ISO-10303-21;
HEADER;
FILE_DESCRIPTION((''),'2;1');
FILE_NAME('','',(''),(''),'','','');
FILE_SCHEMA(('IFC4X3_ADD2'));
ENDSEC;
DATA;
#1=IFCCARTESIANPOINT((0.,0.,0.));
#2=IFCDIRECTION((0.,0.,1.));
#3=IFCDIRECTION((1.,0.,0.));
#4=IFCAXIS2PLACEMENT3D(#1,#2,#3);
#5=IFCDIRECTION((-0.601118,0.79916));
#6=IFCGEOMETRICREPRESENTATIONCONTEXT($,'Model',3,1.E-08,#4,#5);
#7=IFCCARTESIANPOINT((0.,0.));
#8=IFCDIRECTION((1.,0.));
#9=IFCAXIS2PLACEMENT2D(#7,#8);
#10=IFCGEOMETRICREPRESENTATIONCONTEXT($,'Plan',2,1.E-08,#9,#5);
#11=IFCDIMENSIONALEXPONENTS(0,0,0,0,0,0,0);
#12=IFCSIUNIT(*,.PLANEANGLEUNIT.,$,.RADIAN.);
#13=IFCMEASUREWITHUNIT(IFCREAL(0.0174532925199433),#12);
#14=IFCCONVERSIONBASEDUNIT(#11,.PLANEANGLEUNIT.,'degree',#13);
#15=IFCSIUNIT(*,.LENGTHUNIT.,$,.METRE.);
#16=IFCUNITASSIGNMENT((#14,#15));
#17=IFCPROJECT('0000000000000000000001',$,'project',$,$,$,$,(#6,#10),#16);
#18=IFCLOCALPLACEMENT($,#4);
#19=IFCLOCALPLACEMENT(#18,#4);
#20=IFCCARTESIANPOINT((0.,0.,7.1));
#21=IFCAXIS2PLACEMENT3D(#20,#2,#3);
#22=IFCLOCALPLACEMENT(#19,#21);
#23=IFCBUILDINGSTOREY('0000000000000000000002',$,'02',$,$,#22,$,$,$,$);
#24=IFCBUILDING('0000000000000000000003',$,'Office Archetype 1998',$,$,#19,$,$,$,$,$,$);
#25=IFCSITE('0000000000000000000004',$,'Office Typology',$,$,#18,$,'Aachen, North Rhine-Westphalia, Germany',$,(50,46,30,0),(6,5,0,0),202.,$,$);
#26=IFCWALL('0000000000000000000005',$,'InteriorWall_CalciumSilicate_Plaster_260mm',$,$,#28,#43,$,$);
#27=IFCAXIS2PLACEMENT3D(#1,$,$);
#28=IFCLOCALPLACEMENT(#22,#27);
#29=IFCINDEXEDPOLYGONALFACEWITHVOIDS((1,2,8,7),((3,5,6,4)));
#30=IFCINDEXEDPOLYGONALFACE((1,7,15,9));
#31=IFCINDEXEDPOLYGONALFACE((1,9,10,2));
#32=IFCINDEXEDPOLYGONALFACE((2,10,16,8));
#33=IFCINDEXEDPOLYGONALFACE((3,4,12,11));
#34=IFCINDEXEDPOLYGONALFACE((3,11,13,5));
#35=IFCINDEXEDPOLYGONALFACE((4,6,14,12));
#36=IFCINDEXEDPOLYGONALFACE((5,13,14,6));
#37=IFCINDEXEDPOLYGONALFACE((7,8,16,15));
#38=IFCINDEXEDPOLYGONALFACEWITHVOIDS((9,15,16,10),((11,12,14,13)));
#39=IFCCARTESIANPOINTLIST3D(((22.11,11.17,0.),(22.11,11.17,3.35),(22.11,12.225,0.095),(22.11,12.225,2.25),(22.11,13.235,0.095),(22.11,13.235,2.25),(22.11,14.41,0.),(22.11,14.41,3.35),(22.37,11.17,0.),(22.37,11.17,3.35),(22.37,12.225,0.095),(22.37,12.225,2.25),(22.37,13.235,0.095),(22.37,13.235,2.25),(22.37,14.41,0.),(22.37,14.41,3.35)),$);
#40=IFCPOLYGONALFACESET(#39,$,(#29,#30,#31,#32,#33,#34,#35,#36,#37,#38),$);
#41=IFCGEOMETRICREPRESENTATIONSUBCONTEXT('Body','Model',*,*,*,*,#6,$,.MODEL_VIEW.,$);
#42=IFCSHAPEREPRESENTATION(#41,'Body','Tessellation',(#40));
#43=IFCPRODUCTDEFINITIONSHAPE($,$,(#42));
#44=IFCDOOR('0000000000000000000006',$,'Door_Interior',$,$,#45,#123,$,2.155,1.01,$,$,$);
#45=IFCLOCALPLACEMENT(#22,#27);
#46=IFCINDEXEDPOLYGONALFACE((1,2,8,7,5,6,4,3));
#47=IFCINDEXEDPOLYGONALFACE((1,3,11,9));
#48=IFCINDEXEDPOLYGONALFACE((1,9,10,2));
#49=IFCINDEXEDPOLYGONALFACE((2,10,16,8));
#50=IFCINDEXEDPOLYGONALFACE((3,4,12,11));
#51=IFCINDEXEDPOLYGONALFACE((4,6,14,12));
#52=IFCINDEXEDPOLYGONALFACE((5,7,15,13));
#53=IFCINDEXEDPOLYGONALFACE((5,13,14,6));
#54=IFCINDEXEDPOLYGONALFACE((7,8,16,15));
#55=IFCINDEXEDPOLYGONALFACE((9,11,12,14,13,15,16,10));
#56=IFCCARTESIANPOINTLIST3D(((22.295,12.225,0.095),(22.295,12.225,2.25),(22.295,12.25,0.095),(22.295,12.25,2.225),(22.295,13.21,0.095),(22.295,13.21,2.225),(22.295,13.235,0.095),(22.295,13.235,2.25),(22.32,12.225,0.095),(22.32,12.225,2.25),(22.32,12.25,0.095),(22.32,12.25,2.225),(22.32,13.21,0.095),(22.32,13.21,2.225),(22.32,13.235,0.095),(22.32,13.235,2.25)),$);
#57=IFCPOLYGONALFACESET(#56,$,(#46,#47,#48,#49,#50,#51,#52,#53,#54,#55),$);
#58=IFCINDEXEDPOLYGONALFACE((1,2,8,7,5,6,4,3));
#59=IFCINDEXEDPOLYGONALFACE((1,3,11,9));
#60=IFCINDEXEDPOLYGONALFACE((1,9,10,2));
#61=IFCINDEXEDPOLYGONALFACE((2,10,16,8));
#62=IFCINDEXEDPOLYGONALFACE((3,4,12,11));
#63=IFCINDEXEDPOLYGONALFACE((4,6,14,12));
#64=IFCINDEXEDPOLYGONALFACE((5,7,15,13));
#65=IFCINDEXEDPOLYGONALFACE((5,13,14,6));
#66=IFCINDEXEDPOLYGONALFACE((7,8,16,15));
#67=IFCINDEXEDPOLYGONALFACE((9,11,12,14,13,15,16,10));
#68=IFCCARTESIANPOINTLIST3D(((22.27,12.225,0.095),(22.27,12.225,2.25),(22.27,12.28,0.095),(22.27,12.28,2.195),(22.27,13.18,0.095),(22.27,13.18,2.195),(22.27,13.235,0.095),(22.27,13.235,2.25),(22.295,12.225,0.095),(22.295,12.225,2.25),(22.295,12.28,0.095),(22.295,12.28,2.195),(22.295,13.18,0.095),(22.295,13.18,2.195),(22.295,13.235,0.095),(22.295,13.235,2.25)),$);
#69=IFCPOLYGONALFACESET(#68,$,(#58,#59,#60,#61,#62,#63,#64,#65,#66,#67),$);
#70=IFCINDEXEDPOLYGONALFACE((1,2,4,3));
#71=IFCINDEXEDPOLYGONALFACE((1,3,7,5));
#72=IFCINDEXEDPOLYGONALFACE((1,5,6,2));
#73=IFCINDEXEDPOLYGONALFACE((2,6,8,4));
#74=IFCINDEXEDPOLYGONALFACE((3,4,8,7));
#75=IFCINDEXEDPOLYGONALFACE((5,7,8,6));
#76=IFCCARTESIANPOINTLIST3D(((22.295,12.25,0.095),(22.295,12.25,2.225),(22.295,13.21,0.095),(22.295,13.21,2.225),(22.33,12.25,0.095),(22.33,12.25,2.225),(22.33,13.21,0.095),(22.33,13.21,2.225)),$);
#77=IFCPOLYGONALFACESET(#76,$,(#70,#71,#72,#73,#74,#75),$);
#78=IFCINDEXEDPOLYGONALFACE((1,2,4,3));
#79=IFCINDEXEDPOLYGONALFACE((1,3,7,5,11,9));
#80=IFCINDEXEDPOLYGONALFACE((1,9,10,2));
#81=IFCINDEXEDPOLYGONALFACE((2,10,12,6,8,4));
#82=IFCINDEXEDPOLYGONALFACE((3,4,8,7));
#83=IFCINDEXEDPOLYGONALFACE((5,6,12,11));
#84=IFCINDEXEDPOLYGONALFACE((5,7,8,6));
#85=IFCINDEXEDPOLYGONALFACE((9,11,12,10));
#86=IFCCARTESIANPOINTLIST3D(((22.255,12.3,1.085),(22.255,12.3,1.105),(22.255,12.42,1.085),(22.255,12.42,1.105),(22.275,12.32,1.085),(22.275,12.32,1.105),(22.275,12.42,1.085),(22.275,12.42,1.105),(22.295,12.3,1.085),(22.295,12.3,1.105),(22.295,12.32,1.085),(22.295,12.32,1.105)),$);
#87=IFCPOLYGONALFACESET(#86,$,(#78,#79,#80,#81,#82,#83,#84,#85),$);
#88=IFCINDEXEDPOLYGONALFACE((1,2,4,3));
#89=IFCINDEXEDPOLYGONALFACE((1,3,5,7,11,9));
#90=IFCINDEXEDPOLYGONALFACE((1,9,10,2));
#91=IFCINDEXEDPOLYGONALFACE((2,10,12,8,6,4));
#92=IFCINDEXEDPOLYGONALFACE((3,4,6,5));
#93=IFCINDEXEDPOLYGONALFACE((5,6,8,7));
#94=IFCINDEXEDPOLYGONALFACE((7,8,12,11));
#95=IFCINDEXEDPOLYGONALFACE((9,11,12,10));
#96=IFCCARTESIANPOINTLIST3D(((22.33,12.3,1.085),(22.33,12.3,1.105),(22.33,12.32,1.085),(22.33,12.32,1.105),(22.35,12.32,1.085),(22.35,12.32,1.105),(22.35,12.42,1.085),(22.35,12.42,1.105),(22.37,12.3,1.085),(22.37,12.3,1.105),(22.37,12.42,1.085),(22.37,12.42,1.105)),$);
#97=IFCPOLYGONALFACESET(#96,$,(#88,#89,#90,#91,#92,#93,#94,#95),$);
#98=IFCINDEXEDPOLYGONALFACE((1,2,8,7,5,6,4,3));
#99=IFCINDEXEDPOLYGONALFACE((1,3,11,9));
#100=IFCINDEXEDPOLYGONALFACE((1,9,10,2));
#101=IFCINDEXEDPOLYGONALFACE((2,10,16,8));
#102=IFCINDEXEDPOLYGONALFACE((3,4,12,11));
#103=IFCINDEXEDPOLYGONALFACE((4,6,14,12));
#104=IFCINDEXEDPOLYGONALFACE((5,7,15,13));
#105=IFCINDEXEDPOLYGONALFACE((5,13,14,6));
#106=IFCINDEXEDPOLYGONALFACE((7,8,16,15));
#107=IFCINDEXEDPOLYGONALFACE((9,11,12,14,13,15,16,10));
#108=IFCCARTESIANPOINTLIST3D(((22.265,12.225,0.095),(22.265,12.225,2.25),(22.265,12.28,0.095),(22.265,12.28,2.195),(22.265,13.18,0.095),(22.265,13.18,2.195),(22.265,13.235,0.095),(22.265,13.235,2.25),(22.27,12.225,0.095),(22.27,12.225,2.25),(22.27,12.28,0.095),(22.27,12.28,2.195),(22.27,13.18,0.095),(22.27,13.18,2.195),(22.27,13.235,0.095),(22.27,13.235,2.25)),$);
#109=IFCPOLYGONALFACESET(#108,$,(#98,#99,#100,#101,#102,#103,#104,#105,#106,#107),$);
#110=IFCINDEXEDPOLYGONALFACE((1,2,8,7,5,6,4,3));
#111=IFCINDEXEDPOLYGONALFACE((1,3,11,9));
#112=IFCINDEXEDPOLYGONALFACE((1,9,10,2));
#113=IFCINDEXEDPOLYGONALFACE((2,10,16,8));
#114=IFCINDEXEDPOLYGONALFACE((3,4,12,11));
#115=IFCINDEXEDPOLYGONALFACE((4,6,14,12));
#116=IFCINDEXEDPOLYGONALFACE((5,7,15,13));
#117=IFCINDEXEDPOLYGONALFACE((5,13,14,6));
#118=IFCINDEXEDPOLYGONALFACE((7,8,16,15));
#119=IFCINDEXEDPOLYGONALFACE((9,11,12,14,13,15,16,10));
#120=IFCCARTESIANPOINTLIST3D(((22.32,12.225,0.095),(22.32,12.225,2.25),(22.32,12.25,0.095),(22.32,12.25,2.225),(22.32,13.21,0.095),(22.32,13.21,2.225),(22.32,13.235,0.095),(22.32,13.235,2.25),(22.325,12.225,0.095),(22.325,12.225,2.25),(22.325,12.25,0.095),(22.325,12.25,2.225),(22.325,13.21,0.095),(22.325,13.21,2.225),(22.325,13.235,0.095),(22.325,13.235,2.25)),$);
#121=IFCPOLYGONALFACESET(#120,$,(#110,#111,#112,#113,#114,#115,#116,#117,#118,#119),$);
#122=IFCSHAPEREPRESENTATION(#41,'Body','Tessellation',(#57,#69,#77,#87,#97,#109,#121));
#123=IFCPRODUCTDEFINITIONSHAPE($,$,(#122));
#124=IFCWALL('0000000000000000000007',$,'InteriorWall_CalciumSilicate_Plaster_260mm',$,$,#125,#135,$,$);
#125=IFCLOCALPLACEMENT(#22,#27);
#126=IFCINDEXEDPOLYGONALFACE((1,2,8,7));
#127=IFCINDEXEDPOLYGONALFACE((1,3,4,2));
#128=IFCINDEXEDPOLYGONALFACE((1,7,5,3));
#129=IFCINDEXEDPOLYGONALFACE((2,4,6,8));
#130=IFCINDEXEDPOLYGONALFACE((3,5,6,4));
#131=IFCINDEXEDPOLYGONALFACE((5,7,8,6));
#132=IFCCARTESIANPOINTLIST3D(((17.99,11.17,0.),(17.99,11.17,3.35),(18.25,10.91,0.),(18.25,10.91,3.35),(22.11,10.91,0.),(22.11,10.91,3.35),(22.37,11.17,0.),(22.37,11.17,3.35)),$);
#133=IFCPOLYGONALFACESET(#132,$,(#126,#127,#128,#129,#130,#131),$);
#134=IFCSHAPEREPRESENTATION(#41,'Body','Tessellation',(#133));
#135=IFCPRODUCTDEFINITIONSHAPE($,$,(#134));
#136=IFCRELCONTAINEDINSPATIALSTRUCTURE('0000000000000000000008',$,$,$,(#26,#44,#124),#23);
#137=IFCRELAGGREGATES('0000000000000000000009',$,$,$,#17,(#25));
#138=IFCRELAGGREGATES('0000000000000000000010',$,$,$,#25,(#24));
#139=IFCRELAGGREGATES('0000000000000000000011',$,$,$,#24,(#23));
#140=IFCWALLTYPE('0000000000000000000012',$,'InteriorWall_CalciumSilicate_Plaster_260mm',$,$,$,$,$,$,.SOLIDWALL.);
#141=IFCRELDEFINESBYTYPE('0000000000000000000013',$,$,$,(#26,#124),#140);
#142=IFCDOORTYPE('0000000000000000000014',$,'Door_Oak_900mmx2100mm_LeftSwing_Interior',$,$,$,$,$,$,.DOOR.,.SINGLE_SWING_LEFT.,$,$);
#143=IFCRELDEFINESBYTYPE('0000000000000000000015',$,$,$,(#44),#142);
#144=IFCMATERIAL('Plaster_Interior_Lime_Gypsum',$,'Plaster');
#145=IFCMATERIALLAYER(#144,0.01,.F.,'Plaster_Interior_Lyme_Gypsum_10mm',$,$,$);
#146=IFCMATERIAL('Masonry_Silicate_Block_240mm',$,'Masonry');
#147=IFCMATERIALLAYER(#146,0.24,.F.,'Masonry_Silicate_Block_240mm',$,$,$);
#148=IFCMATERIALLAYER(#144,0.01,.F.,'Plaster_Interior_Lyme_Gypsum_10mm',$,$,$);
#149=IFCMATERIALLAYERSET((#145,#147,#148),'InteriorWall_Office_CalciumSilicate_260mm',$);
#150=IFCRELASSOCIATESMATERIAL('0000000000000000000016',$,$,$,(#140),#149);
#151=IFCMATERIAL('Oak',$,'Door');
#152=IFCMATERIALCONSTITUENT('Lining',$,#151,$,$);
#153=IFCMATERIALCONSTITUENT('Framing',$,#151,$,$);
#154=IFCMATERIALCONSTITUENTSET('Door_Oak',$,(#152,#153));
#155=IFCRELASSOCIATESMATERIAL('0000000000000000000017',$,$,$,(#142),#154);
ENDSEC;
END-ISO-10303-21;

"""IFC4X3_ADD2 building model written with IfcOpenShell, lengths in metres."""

from ifc_helpers import new_model, entity, si_unit, converted_unit, direction, frame, origin_with_axes, origin_2d_with_axis, place, context, subcontext, project, spatial, line, indexed_curve, outline, extrude, source, transform, mapped, material, layer, layer_set, constituent, constituent_set, type_object, type_shapes, element, fill, save


model = new_model("IFC4X3_ADD2")

# Units and contexts
model_context = context("Model", 3, precision=1e-08, world=origin_with_axes(), true_north=direction((-0.601118, 0.79916)))
plan_context = context("Plan", 2, precision=1e-08, world=origin_2d_with_axis(), true_north=direction((-0.601118, 0.79916)))
body_context = subcontext(model_context, "Body", "Model", "MODEL_VIEW")
ifc_project = project(units=[converted_unit("PLANEANGLEUNIT", "degree", entity("IfcReal", 0.0174532925199433), si_unit("PLANEANGLEUNIT", "RADIAN"), dimensions=[0, 0, 0, 0, 0, 0, 0]), si_unit("LENGTHUNIT", "METRE")], contexts=[model_context, plan_context])

# Site, building, storey
site_placement = place(None, origin_with_axes())
site = spatial("IfcSite", under=ifc_project, at=site_placement, Name="Office Typology", LongName="Aachen, North Rhine-Westphalia, Germany", RefLatitude=(50, 46, 30, 0), RefLongitude=(6, 5, 0, 0), RefElevation=202.0)
building_placement = place(site_placement, origin_with_axes())
building = spatial("IfcBuilding", under=site, at=building_placement, Name="Office Archetype 1998")
storey_placement = place(building_placement, frame((0.0, 0.0, 7.1), z_axis=(0.0, 0.0, 1.0), x_axis=(1.0, 0.0, 0.0)))
storey = spatial("IfcBuildingStorey", under=building, at=storey_placement, Name="02")

# Wall, opening, door
ifc_material_1 = material(Name="Plaster_Interior_Lime_Gypsum", Category="Plaster")
ifc_layer_1 = layer(ifc_material_1, 0.01, ventilated=False, Name="Plaster_Interior_Lyme_Gypsum_10mm")
ifc_material_2 = material(Name="Masonry_Silicate_Block_240mm", Category="Masonry")
ifc_layer_2 = layer(ifc_material_2, 0.24, ventilated=False, Name="Masonry_Silicate_Block_240mm")
ifc_layer_3 = layer(ifc_material_1, 0.01, ventilated=False, Name="Plaster_Interior_Lyme_Gypsum_10mm")
ifc_layer_set = layer_set([ifc_layer_1, ifc_layer_2, ifc_layer_3], Name="InteriorWall_Office_CalciumSilicate_260mm")
wall_type = type_object("IfcWallType", Name="InteriorWall_CalciumSilicate_Plaster_260mm", PredefinedType="SOLIDWALL", material=ifc_layer_set)
wall_1_placement = place(storey_placement, frame((22.37, 11.17, 0.0), z_axis=(0.0, 0.0, 1.0), x_axis=(0.0, 1.0, 0.0)))
wall_1 = element("IfcWall", 1, at=wall_1_placement, inside=storey, type_object=wall_type, Name="InteriorWall_CalciumSilicate_Plaster_260mm", context=body_context, shape_type="SweptSolid", body=[
    extrude(outline(indexed_curve([(0.0, 0.0), (0.0, 0.26), (3.24, 0.26), (3.24, 0.0)], segments=[line(1, 2, 3, 4, 1)])), origin_with_axes(), (0.0, 0.0, 1.0), 3.35),
])
shared_shape_1 = source(origin_with_axes(), body_context, "Body", "SweptSolid", [
    extrude(outline(indexed_curve([(0.0, 2.155), (1.01, 2.155), (1.01, 0.0), (0.0, 0.0), (0.0, 2.155)])), frame((0.0, -0.015, 0.0), z_axis=(0.0, -1.0, 0.0), x_axis=(1.0, 0.0, 0.0)), (0.0, 0.0, -1.0), 0.26),
])
opening_placement = place(wall_1_placement, frame((2.065, 0.245, 0.095), z_axis=(0.0, 0.0, 1.0), x_axis=(-1.0, 0.0, 0.0)))
opening = element("IfcOpeningElement", 2, at=opening_placement, cuts=wall_1, PredefinedType="OPENING", context=body_context, shape_type="MappedRepresentation", body=[
    mapped(shared_shape_1, transform((0.0, 0.0, 0.0), x_axis=(1.0, 0.0, 0.0), y_axis=(0.0, 1.0, 0.0), z_axis=(0.0, 0.0, 1.0), scale=1.0)),
])
ifc_material_3 = material(Name="Oak", Category="Door")
ifc_constituent_1 = constituent(ifc_material_3, Name="Lining")
ifc_constituent_2 = constituent(ifc_material_3, Name="Framing")
ifc_constituent_set = constituent_set(constituents=[ifc_constituent_1, ifc_constituent_2], Name="Door_Oak")
door_type = type_object("IfcDoorType", Name="Door_Oak_900mmx2100mm_LeftSwing_Interior", OperationType="SINGLE_SWING_LEFT", PredefinedType="DOOR", material=ifc_constituent_set)
shared_shape_2 = source(origin_with_axes(), body_context, "Body", "SweptSolid", [
    extrude(outline(indexed_curve([(0.0, 0.0), (0.0, 2.155), (1.01, 2.155), (1.01, 0.0), (0.985, 0.0), (0.985, 2.13), (0.025, 2.13), (0.025, 0.0)], segments=[line(1, 2, 3, 4, 5, 6, 7, 8, 1)])), frame((0.0, 0.025, 0.0), z_axis=(0.0, -1.0, 0.0), x_axis=(1.0, 0.0, 0.0)), (0.0, 0.0, -1.0), 0.025),
    extrude(outline(indexed_curve([(0.0, 0.0), (0.0, 2.155), (1.01, 2.155), (1.01, 0.0), (0.955, 0.0), (0.955, 2.1), (0.055, 2.1), (0.055, 0.0)], segments=[line(1, 2, 3, 4, 5, 6, 7, 8, 1)])), frame((0.0, 0.0, 0.0), z_axis=(0.0, -1.0, 0.0), x_axis=(1.0, 0.0, 0.0)), (0.0, 0.0, -1.0), 0.025),
    extrude(outline(indexed_curve([(0.0, 0.0), (0.96, 0.0), (0.96, 0.035), (0.0, 0.035)], segments=[line(1, 2, 3, 4, 1)])), frame((0.025, 0.025, 0.0), z_axis=(0.0, 0.0, 1.0), x_axis=(1.0, 0.0, 0.0)), (0.0, 0.0, 1.0), 2.13),
    extrude(outline(indexed_curve([(0.0, 0.0), (0.0, -0.04), (-0.12, -0.04), (-0.12, -0.02), (-0.02, -0.02), (-0.02, 0.0)], segments=[line(1, 2, 3, 4, 5, 6, 1)])), frame((0.935, 0.025, 0.99), z_axis=(0.0, 0.0, 1.0), x_axis=(1.0, 0.0, 0.0)), (0.0, 0.0, 1.0), 0.02),
    extrude(outline(indexed_curve([(0.0, 0.0), (0.0, 0.04), (-0.12, 0.04), (-0.12, 0.02), (-0.02, 0.02), (-0.02, 0.0)], segments=[line(1, 2, 3, 4, 5, 6, 1)])), frame((0.935, 0.06, 0.99), z_axis=(0.0, 0.0, 1.0), x_axis=(1.0, 0.0, 0.0)), (0.0, 0.0, 1.0), 0.02),
    extrude(outline(indexed_curve([(0.0, 0.0), (0.0, 2.155), (1.01, 2.155), (1.01, 0.0), (0.955, 0.0), (0.955, 2.1), (0.055, 2.1), (0.055, 0.0)], segments=[line(1, 2, 3, 4, 5, 6, 7, 8, 1)])), frame((0.0, -0.005, 0.0), z_axis=(0.0, -1.0, 0.0), x_axis=(1.0, 0.0, 0.0)), (0.0, 0.0, -1.0), 0.005),
    extrude(outline(indexed_curve([(0.0, 0.0), (0.0, 2.155), (1.01, 2.155), (1.01, 0.0), (0.985, 0.0), (0.985, 2.13), (0.025, 2.13), (0.025, 0.0)], segments=[line(1, 2, 3, 4, 5, 6, 7, 8, 1)])), frame((0.0, 0.05, 0.0), z_axis=(0.0, -1.0, 0.0), x_axis=(1.0, 0.0, 0.0)), (0.0, 0.0, -1.0), 0.005),
])
type_shapes(door_type, [shared_shape_2])
door_placement = place(opening_placement, frame((0.0, 0.145, 0.0), z_axis=(0.0, 0.0, 1.0), x_axis=(1.0, 0.0, 0.0)))
door = element("IfcDoor", 3, at=door_placement, inside=storey, type_object=door_type, Name="Door_Interior", OverallHeight=2.155, OverallWidth=1.01, context=body_context, shape_type="MappedRepresentation", body=[
    mapped(shared_shape_2, transform((0.0, 0.0, 0.0), x_axis=(1.0, 0.0, 0.0), y_axis=(0.0, 1.0, 0.0), z_axis=(0.0, 0.0, 1.0), scale=1.0)),
])
fill(opening, door)

# Wall
wall_2_placement = place(storey_placement, frame((22.37, 11.17, 0.0), z_axis=(0.0, 0.0, 1.0), x_axis=(-1.0, 0.0, 0.0)))
element("IfcWall", 4, at=wall_2_placement, inside=storey, type_object=wall_type, Name="InteriorWall_CalciumSilicate_Plaster_260mm", context=body_context, shape_type="SweptSolid", body=[
    extrude(outline(indexed_curve([(0.0, 0.0), (0.26, 0.26), (4.12, 0.26), (4.38, 0.0)], segments=[line(1, 2, 3, 4, 1)])), origin_with_axes(), (0.0, 0.0, 1.0), 3.35),
])

save(model, "model.ifc")
